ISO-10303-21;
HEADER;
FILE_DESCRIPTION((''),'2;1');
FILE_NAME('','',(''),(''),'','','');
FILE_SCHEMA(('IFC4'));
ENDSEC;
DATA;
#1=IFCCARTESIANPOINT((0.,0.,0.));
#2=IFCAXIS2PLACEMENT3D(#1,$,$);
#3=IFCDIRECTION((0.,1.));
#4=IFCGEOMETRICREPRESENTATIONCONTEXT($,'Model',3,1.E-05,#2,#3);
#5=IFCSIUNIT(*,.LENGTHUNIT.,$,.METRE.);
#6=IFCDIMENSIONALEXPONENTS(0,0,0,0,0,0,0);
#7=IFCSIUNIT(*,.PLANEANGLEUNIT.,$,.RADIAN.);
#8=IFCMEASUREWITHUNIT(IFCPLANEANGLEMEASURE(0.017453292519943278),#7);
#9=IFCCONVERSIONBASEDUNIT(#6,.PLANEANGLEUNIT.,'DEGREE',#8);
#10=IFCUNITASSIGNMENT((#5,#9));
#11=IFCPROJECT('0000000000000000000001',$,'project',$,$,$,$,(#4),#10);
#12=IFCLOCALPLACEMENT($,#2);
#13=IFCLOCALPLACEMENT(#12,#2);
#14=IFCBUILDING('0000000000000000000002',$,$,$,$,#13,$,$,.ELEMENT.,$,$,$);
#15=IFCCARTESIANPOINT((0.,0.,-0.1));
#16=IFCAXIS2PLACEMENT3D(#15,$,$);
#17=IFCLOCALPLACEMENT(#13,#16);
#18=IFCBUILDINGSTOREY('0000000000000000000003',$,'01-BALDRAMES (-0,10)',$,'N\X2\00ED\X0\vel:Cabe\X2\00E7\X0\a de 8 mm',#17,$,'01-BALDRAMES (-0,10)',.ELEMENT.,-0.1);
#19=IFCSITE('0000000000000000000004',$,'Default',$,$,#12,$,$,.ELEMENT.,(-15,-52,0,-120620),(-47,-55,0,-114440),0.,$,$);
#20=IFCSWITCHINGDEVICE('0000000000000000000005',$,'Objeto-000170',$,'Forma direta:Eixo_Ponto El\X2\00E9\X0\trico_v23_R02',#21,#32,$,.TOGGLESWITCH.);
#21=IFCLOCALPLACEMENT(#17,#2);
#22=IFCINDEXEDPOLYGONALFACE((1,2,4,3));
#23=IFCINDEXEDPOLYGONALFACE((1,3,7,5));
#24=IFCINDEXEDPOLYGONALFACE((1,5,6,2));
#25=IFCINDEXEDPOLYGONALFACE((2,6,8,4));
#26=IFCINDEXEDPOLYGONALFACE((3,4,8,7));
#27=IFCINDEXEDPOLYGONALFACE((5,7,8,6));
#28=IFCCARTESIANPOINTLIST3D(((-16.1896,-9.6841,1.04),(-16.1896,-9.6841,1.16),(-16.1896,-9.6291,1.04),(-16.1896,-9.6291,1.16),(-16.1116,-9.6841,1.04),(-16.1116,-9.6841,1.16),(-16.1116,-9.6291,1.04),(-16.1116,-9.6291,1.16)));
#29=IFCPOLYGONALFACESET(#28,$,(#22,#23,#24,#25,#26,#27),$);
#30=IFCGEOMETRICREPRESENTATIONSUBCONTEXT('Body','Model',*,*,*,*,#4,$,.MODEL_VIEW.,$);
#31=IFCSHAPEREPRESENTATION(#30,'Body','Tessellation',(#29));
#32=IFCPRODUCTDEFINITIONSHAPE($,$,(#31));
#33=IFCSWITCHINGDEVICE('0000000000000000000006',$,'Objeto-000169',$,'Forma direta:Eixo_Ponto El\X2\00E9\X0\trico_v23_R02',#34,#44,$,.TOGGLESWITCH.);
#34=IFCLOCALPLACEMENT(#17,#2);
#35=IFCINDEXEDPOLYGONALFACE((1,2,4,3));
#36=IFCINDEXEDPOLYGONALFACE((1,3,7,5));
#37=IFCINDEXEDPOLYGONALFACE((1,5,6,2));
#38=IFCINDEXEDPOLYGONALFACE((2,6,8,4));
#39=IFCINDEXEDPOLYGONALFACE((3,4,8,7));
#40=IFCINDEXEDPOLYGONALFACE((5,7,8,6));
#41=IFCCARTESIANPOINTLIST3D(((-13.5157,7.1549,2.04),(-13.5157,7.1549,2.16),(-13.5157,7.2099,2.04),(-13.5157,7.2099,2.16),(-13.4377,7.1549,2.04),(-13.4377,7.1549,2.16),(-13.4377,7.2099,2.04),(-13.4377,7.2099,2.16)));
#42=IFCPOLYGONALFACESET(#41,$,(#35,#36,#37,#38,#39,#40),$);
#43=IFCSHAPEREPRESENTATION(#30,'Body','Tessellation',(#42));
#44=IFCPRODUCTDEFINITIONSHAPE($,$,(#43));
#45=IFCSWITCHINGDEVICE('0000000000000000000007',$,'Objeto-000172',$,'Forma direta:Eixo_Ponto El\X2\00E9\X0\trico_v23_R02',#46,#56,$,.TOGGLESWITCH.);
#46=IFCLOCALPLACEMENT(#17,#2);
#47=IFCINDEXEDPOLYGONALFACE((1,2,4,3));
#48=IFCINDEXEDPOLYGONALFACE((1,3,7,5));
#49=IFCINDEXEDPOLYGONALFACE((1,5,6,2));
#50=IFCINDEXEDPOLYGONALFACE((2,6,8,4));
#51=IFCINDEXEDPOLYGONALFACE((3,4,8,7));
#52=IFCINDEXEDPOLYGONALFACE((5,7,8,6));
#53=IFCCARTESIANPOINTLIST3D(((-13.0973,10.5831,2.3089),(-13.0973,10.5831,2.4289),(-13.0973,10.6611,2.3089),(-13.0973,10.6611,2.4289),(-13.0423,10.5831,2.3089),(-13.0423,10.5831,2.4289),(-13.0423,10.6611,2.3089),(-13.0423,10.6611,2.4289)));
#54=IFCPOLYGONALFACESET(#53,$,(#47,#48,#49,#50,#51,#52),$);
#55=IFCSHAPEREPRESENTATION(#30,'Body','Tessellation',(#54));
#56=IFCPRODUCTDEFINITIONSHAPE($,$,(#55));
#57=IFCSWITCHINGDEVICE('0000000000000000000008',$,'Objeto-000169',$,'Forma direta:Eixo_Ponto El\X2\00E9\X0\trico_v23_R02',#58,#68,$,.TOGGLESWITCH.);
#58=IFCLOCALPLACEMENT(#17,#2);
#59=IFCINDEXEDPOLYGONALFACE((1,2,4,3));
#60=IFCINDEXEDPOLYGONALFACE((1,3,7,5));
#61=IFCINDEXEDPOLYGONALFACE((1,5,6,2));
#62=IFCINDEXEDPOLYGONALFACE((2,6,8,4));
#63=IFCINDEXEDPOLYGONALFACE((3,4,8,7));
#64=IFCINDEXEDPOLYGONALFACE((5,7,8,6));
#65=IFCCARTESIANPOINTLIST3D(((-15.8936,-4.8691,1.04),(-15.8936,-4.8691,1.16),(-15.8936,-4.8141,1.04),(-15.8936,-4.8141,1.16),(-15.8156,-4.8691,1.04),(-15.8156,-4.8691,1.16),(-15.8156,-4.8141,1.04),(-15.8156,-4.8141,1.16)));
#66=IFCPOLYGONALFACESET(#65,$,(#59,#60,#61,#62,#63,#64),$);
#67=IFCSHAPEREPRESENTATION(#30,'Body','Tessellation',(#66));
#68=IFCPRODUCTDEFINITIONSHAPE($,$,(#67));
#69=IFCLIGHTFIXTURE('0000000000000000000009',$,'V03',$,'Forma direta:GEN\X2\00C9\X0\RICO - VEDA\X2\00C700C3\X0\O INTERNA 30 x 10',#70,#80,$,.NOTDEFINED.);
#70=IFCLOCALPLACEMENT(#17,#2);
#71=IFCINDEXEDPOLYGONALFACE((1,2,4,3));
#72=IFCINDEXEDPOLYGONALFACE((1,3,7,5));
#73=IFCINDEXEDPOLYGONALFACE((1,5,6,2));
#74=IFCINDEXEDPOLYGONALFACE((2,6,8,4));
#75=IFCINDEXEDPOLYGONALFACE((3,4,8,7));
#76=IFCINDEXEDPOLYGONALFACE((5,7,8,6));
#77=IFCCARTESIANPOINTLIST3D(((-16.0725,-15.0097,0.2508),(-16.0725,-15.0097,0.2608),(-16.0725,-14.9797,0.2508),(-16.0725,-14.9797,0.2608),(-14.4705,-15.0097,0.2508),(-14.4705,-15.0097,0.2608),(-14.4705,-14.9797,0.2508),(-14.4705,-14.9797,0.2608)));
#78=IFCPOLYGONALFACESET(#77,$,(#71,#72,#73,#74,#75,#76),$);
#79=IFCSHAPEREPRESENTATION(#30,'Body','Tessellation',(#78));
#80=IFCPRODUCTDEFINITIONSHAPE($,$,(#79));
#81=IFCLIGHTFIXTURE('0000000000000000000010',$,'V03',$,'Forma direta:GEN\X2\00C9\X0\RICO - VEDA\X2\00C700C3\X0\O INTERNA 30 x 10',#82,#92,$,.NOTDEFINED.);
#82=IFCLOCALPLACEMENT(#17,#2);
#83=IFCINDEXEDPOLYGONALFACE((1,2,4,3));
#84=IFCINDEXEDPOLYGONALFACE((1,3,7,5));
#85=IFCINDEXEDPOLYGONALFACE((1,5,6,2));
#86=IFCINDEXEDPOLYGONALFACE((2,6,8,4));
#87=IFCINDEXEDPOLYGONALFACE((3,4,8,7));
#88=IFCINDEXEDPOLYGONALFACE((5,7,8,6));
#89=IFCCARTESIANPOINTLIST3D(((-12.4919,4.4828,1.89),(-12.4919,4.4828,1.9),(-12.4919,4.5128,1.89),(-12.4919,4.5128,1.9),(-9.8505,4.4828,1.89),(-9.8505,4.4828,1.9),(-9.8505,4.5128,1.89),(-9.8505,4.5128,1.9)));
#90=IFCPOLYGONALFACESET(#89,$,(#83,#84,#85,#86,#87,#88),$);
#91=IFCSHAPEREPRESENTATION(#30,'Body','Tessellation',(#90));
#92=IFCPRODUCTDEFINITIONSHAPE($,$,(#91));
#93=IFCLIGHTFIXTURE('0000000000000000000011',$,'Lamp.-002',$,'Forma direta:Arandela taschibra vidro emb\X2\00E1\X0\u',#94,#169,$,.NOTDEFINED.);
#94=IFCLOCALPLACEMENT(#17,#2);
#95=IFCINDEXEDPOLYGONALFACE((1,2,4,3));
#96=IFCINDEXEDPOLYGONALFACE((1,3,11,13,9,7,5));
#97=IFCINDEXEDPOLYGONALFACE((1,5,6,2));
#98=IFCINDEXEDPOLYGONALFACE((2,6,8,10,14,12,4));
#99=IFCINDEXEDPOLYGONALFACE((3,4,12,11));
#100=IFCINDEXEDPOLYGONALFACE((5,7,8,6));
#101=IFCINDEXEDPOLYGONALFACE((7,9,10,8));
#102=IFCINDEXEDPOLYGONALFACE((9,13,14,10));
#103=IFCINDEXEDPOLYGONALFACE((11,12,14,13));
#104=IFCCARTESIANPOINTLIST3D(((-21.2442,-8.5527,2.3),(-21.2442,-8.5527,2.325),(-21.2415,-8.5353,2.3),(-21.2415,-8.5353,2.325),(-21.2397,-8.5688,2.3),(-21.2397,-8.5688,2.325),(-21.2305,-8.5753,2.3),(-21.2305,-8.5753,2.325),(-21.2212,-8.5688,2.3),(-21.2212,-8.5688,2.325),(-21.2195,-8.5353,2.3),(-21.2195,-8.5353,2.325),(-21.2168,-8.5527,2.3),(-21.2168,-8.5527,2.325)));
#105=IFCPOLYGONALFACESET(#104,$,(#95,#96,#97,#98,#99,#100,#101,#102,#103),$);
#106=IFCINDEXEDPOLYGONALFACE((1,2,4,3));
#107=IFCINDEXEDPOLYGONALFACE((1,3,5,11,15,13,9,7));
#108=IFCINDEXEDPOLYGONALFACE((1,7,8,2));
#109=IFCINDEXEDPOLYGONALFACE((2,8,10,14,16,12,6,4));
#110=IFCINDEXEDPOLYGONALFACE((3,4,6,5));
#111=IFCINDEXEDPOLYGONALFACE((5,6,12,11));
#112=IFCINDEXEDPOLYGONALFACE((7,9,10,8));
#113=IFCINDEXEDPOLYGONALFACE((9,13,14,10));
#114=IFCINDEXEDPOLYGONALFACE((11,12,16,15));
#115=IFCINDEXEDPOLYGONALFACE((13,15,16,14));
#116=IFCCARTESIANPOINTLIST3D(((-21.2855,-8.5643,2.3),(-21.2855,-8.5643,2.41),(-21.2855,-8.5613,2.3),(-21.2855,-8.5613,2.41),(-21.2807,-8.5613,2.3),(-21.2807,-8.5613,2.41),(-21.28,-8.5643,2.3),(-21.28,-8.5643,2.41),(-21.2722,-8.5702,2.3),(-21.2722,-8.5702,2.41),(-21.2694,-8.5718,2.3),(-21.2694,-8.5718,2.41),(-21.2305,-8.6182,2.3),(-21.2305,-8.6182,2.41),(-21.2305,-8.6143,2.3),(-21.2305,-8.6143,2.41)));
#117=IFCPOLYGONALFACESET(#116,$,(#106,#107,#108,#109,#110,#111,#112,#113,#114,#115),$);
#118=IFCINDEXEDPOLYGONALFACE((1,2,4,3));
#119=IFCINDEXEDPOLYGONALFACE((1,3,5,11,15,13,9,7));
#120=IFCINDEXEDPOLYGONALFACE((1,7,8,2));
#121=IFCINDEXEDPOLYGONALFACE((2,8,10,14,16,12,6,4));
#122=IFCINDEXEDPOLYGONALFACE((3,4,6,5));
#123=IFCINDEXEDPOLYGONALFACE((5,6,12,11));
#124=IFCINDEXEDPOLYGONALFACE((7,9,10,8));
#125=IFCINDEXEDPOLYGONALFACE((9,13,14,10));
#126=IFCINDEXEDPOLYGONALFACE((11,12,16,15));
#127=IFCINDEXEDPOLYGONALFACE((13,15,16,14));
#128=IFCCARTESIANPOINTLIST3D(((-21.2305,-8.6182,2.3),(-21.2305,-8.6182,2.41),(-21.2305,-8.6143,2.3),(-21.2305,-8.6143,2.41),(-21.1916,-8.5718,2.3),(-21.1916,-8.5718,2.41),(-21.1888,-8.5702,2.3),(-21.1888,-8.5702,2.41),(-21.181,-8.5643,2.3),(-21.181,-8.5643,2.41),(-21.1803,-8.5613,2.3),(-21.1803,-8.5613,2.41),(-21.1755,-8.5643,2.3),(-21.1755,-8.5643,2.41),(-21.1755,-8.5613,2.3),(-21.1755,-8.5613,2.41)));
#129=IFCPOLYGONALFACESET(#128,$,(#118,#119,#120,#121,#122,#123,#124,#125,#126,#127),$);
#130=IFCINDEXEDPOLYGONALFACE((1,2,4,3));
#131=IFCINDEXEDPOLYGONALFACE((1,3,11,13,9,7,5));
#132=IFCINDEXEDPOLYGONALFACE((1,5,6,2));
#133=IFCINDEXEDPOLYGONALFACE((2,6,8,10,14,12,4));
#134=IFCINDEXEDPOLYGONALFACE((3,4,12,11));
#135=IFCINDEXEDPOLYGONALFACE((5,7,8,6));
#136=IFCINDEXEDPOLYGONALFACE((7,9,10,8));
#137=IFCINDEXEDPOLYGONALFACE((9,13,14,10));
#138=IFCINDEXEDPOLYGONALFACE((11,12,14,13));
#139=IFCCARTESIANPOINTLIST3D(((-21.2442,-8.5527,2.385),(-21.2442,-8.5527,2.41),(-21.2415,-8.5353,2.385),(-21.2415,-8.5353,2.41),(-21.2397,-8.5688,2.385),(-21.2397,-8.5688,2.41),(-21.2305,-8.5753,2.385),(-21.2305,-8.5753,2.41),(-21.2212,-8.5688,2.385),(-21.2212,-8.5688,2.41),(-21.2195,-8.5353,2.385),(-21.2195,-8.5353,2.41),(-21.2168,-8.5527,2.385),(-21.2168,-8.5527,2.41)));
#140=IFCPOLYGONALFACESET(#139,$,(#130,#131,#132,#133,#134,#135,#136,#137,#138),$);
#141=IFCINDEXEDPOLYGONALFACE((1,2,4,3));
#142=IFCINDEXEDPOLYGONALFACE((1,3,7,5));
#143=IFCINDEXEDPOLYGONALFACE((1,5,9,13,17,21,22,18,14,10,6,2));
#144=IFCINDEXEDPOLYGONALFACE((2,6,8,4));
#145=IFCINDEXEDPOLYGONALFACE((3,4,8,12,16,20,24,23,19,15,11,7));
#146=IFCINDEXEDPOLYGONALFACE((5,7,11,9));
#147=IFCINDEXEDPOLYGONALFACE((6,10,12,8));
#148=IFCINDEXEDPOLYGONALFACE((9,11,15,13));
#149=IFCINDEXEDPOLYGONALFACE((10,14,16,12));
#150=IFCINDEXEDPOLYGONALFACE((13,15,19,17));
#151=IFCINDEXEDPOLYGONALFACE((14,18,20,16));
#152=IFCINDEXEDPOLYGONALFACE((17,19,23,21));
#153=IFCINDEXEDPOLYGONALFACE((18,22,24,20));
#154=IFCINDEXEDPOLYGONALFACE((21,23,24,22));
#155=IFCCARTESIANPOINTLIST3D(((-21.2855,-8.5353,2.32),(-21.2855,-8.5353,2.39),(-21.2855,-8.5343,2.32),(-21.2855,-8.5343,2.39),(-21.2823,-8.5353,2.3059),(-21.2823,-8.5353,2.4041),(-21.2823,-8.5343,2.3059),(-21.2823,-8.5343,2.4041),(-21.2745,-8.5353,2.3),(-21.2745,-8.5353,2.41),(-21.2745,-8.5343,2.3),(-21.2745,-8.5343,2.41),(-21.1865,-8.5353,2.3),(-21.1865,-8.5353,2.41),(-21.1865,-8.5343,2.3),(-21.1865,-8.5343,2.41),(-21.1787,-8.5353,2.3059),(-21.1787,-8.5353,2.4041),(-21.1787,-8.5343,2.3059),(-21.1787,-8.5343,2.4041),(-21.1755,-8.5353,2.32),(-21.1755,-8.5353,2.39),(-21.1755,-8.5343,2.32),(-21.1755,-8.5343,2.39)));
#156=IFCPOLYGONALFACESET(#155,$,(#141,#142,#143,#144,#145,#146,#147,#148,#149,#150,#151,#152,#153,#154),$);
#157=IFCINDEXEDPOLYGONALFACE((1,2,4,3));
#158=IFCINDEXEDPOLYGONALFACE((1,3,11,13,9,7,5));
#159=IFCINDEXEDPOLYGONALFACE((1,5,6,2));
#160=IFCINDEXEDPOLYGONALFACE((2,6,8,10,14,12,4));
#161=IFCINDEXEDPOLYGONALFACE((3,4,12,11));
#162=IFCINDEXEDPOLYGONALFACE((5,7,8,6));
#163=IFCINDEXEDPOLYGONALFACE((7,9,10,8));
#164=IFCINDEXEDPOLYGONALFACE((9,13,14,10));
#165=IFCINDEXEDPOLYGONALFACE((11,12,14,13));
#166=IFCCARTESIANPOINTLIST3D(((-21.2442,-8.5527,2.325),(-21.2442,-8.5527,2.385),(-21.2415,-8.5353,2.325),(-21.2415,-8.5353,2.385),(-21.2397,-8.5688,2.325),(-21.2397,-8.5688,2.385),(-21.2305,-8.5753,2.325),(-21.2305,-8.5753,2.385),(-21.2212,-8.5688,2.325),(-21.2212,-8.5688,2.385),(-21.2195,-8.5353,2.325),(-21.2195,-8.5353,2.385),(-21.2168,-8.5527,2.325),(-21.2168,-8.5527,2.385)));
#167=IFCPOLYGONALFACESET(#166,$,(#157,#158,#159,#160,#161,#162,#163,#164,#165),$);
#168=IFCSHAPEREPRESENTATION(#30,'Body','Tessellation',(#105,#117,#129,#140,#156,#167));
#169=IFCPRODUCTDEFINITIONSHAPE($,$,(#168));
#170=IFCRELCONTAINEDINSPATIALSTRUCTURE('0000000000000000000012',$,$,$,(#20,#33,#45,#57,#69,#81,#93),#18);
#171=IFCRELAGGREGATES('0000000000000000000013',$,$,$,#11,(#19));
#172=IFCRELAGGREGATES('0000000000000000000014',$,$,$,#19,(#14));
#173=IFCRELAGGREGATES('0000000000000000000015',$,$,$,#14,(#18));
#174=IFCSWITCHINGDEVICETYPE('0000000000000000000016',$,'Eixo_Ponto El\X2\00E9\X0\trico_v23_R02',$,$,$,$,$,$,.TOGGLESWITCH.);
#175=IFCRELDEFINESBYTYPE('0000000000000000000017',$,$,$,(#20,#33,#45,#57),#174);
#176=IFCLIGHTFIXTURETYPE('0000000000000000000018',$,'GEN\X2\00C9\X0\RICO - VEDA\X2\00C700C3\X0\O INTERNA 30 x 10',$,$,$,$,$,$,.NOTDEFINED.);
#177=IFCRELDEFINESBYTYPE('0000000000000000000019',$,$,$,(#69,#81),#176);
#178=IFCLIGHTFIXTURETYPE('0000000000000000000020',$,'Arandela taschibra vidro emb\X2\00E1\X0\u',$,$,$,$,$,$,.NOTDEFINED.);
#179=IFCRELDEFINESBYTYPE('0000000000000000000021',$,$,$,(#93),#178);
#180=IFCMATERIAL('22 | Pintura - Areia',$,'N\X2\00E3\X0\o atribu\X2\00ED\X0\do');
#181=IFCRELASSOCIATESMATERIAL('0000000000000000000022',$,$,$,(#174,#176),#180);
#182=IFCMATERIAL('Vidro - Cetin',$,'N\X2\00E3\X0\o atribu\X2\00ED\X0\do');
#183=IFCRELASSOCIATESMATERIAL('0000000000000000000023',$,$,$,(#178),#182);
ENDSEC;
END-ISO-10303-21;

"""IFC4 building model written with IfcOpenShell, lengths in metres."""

from ifc_helpers import new_model, entity, si_unit, converted_unit, direction, frame, origin, place, context, subcontext, project, spatial, indexed_curve, outline, extrude, material, type_object, element, save


model = new_model("IFC4")

# Units and contexts
model_context = context("Model", 3, precision=1e-05, world=origin(), true_north=direction((0.0, 1.0)))
body_context = subcontext(model_context, "Body", "Model", "MODEL_VIEW")
ifc_project = project(units=[si_unit("LENGTHUNIT", "METRE"), converted_unit("PLANEANGLEUNIT", "DEGREE", entity("IfcPlaneAngleMeasure", 0.017453292519943278), si_unit("PLANEANGLEUNIT", "RADIAN"), dimensions=[0, 0, 0, 0, 0, 0, 0])], contexts=[model_context])

# Site, building, storey
site_placement = place(None, origin())
site = spatial("IfcSite", under=ifc_project, at=site_placement, Name="Default", CompositionType="ELEMENT", RefLatitude=(-15, -52, 0, -120620), RefLongitude=(-47, -55, 0, -114440), RefElevation=0.0)
building_placement = place(site_placement, origin())
building = spatial("IfcBuilding", under=site, at=building_placement, CompositionType="ELEMENT")
storey_placement = place(building_placement, frame((0.0, 0.0, -0.1)))
storey = spatial("IfcBuildingStorey", under=building, at=storey_placement, Name="01-BALDRAMES (-0,10)", ObjectType="Nível:Cabeça de 8 mm", LongName="01-BALDRAMES (-0,10)", CompositionType="ELEMENT", Elevation=-0.1)

# Switching devices
ifc_material_1 = material(Name="22 | Pintura - Areia", Category="Não atribuído")
switching_device_type = type_object("IfcSwitchingDeviceType", Name="Eixo_Ponto Elétrico_v23_R02", PredefinedType="TOGGLESWITCH", material=ifc_material_1)
switching_device_1_placement = place(storey_placement, origin())
element("IfcSwitchingDevice", 1, at=switching_device_1_placement, inside=storey, type_object=switching_device_type, Name="Objeto-000170", ObjectType="Forma direta:Eixo_Ponto Elétrico_v23_R02", PredefinedType="TOGGLESWITCH", context=body_context, shape_type="SweptSolid", body=[
    extrude(outline(indexed_curve([(-0.0275, -0.039), (0.0275, -0.039), (0.0275, 0.039), (-0.0275, 0.039), (-0.0275, -0.039)], self_intersect=False)), frame((-16.1506, -9.6566, 1.04), z_axis=(0.0, 0.0, 1.0), x_axis=(-0.000011, -1.0, 0.0)), (0.0, 0.0, 1.0), 0.12),
])
switching_device_2_placement = place(storey_placement, origin())
element("IfcSwitchingDevice", 2, at=switching_device_2_placement, inside=storey, type_object=switching_device_type, Name="Objeto-000169", ObjectType="Forma direta:Eixo_Ponto Elétrico_v23_R02", PredefinedType="TOGGLESWITCH", context=body_context, shape_type="SweptSolid", body=[
    extrude(outline(indexed_curve([(-0.039, -0.0275), (0.039, -0.0275), (0.039, 0.0275), (-0.039, 0.0275), (-0.039, -0.0275)], self_intersect=False)), frame((-13.4767, 7.1824, 2.04)), (0.0, 0.0, 1.0), 0.12),
])
switching_device_3_placement = place(storey_placement, origin())
element("IfcSwitchingDevice", 3, at=switching_device_3_placement, inside=storey, type_object=switching_device_type, Name="Objeto-000172", ObjectType="Forma direta:Eixo_Ponto Elétrico_v23_R02", PredefinedType="TOGGLESWITCH", context=body_context, shape_type="SweptSolid", body=[
    extrude(outline(indexed_curve([(-0.0275, -0.039), (0.0275, -0.039), (0.0275, 0.039), (-0.0275, 0.039), (-0.0275, -0.039)], self_intersect=False)), frame((-13.0698, 10.6221, 2.3089), z_axis=(0.0, 0.0, 1.0), x_axis=(-1.0, 0.000013, 0.0)), (0.0, 0.0, 1.0), 0.12),
])
switching_device_4_placement = place(storey_placement, origin())
element("IfcSwitchingDevice", 4, at=switching_device_4_placement, inside=storey, type_object=switching_device_type, Name="Objeto-000169", ObjectType="Forma direta:Eixo_Ponto Elétrico_v23_R02", PredefinedType="TOGGLESWITCH", context=body_context, shape_type="SweptSolid", body=[
    extrude(outline(indexed_curve([(-0.0275, -0.039), (0.0275, -0.039), (0.0275, 0.039), (-0.0275, 0.039), (-0.0275, -0.039)], self_intersect=False)), frame((-15.8546, -4.8416, 1.04), z_axis=(0.0, 0.0, 1.0), x_axis=(-0.000013, -1.0, 0.0)), (0.0, 0.0, 1.0), 0.12),
])

# Light fixtures
light_fixture_type_1 = type_object("IfcLightFixtureType", Name="GENÉRICO - VEDAÇÃO INTERNA 30 x 10", PredefinedType="NOTDEFINED", material=ifc_material_1)
light_fixture_1_placement = place(storey_placement, origin())
element("IfcLightFixture", 5, at=light_fixture_1_placement, inside=storey, type_object=light_fixture_type_1, Name="V03", ObjectType="Forma direta:GENÉRICO - VEDAÇÃO INTERNA 30 x 10", PredefinedType="NOTDEFINED", context=body_context, shape_type="SweptSolid", body=[
    extrude(outline(indexed_curve([(-0.801, -0.015), (0.801, -0.015), (0.801, 0.015), (-0.801, 0.015), (-0.801, -0.015)], self_intersect=False)), frame((-15.2715, -14.9947, 0.2508)), (0.0, 0.0, 1.0), 0.01),
])
light_fixture_2_placement = place(storey_placement, origin())
element("IfcLightFixture", 6, at=light_fixture_2_placement, inside=storey, type_object=light_fixture_type_1, Name="V03", ObjectType="Forma direta:GENÉRICO - VEDAÇÃO INTERNA 30 x 10", PredefinedType="NOTDEFINED", context=body_context, shape_type="SweptSolid", body=[
    extrude(outline(indexed_curve([(-1.3207, -0.015), (1.3207, -0.015), (1.3207, 0.015), (-1.3207, 0.015), (-1.3207, -0.015)], self_intersect=False)), frame((-11.1712, 4.4978, 1.89)), (0.0, 0.0, 1.0), 0.01),
])
ifc_material_2 = material(Name="Vidro - Cetin", Category="Não atribuído")
light_fixture_type_2 = type_object("IfcLightFixtureType", Name="Arandela taschibra vidro embáu", PredefinedType="NOTDEFINED", material=ifc_material_2)
light_fixture_3_placement = place(storey_placement, origin())
element("IfcLightFixture", 7, at=light_fixture_3_placement, inside=storey, type_object=light_fixture_type_2, Name="Lamp.-002", ObjectType="Forma direta:Arandela taschibra vidro embáu", PredefinedType="NOTDEFINED", context=body_context, shape_type="SweptSolid", body=[
    extrude(outline(indexed_curve([(-0.0183, -0.014), (-0.0008, -0.014), (0.0145, -0.0071), (0.0195, 0.003), (0.0117, 0.0112), (-0.0049, 0.0131), (-0.0217, 0.0078), (-0.0183, -0.014)], self_intersect=False)), frame((-21.2305, -8.5556, 2.3), z_axis=(0.0, 0.0, 1.0), x_axis=(-0.153045, -0.988219, 0.0)), (0.0, 0.0, 1.0), 0.025),
    extrude(outline(indexed_curve([(-0.0169, -0.0187), (-0.0139, -0.0187), (-0.0139, -0.0132), (-0.008, -0.0054), (0.04, 0.0363), (0.0361, 0.0363), (-0.0065, -0.0026), (-0.0169, -0.0139), (-0.0169, -0.0187)], self_intersect=False)), frame((-21.2668, -8.5782, 2.3), z_axis=(0.0, 0.0, 1.0), x_axis=(-0.000013, -1.0, 0.0)), (0.0, 0.0, 1.0), 0.11),
    extrude(outline(indexed_curve([(-0.0187, -0.0169), (-0.0139, -0.0169), (-0.0026, -0.0065), (0.0363, 0.0361), (0.0363, 0.04), (-0.0054, -0.008), (-0.0132, -0.0139), (-0.0187, -0.0139), (-0.0187, -0.0169)], self_intersect=False)), frame((-21.1942, -8.5782, 2.3), z_axis=(0.0, 0.0, 1.0), x_axis=(-1.0, -0.000785, 0.0)), (0.0, 0.0, 1.0), 0.11),
    extrude(outline(indexed_curve([(-0.0183, -0.014), (-0.0008, -0.014), (0.0145, -0.0071), (0.0195, 0.003), (0.0117, 0.0112), (-0.0049, 0.0131), (-0.0217, 0.0078), (-0.0183, -0.014)], self_intersect=False)), frame((-21.2305, -8.5556, 2.385), z_axis=(0.0, 0.0, 1.0), x_axis=(-0.153045, -0.988219, 0.0)), (0.0, 0.0, 1.0), 0.025),
    extrude(outline(indexed_curve([(-0.044, -0.055), (0.044, -0.055), (0.0518, -0.0491), (0.055, -0.035), (0.055, 0.035), (0.0518, 0.0491), (0.044, 0.055), (-0.044, 0.055), (-0.0518, 0.0491), (-0.055, 0.035), (-0.055, -0.035), (-0.0518, -0.0491), (-0.044, -0.055)], self_intersect=False)), frame((-21.2305, -8.5353, 2.355), z_axis=(0.000013, 1.0, 0.0), x_axis=(-1.0, 0.000013, 0.0)), (0.0, 0.0, 1.0), 0.001),
    extrude(outline(indexed_curve([(-0.0183, -0.014), (-0.0008, -0.014), (0.0145, -0.0071), (0.0195, 0.003), (0.0117, 0.0112), (-0.0049, 0.0131), (-0.0217, 0.0078), (-0.0183, -0.014)], self_intersect=False)), frame((-21.2305, -8.5556, 2.325), z_axis=(0.0, 0.0, 1.0), x_axis=(-0.153045, -0.988219, 0.0)), (0.0, 0.0, 1.0), 0.06),
])

save(model, "model.ifc")
